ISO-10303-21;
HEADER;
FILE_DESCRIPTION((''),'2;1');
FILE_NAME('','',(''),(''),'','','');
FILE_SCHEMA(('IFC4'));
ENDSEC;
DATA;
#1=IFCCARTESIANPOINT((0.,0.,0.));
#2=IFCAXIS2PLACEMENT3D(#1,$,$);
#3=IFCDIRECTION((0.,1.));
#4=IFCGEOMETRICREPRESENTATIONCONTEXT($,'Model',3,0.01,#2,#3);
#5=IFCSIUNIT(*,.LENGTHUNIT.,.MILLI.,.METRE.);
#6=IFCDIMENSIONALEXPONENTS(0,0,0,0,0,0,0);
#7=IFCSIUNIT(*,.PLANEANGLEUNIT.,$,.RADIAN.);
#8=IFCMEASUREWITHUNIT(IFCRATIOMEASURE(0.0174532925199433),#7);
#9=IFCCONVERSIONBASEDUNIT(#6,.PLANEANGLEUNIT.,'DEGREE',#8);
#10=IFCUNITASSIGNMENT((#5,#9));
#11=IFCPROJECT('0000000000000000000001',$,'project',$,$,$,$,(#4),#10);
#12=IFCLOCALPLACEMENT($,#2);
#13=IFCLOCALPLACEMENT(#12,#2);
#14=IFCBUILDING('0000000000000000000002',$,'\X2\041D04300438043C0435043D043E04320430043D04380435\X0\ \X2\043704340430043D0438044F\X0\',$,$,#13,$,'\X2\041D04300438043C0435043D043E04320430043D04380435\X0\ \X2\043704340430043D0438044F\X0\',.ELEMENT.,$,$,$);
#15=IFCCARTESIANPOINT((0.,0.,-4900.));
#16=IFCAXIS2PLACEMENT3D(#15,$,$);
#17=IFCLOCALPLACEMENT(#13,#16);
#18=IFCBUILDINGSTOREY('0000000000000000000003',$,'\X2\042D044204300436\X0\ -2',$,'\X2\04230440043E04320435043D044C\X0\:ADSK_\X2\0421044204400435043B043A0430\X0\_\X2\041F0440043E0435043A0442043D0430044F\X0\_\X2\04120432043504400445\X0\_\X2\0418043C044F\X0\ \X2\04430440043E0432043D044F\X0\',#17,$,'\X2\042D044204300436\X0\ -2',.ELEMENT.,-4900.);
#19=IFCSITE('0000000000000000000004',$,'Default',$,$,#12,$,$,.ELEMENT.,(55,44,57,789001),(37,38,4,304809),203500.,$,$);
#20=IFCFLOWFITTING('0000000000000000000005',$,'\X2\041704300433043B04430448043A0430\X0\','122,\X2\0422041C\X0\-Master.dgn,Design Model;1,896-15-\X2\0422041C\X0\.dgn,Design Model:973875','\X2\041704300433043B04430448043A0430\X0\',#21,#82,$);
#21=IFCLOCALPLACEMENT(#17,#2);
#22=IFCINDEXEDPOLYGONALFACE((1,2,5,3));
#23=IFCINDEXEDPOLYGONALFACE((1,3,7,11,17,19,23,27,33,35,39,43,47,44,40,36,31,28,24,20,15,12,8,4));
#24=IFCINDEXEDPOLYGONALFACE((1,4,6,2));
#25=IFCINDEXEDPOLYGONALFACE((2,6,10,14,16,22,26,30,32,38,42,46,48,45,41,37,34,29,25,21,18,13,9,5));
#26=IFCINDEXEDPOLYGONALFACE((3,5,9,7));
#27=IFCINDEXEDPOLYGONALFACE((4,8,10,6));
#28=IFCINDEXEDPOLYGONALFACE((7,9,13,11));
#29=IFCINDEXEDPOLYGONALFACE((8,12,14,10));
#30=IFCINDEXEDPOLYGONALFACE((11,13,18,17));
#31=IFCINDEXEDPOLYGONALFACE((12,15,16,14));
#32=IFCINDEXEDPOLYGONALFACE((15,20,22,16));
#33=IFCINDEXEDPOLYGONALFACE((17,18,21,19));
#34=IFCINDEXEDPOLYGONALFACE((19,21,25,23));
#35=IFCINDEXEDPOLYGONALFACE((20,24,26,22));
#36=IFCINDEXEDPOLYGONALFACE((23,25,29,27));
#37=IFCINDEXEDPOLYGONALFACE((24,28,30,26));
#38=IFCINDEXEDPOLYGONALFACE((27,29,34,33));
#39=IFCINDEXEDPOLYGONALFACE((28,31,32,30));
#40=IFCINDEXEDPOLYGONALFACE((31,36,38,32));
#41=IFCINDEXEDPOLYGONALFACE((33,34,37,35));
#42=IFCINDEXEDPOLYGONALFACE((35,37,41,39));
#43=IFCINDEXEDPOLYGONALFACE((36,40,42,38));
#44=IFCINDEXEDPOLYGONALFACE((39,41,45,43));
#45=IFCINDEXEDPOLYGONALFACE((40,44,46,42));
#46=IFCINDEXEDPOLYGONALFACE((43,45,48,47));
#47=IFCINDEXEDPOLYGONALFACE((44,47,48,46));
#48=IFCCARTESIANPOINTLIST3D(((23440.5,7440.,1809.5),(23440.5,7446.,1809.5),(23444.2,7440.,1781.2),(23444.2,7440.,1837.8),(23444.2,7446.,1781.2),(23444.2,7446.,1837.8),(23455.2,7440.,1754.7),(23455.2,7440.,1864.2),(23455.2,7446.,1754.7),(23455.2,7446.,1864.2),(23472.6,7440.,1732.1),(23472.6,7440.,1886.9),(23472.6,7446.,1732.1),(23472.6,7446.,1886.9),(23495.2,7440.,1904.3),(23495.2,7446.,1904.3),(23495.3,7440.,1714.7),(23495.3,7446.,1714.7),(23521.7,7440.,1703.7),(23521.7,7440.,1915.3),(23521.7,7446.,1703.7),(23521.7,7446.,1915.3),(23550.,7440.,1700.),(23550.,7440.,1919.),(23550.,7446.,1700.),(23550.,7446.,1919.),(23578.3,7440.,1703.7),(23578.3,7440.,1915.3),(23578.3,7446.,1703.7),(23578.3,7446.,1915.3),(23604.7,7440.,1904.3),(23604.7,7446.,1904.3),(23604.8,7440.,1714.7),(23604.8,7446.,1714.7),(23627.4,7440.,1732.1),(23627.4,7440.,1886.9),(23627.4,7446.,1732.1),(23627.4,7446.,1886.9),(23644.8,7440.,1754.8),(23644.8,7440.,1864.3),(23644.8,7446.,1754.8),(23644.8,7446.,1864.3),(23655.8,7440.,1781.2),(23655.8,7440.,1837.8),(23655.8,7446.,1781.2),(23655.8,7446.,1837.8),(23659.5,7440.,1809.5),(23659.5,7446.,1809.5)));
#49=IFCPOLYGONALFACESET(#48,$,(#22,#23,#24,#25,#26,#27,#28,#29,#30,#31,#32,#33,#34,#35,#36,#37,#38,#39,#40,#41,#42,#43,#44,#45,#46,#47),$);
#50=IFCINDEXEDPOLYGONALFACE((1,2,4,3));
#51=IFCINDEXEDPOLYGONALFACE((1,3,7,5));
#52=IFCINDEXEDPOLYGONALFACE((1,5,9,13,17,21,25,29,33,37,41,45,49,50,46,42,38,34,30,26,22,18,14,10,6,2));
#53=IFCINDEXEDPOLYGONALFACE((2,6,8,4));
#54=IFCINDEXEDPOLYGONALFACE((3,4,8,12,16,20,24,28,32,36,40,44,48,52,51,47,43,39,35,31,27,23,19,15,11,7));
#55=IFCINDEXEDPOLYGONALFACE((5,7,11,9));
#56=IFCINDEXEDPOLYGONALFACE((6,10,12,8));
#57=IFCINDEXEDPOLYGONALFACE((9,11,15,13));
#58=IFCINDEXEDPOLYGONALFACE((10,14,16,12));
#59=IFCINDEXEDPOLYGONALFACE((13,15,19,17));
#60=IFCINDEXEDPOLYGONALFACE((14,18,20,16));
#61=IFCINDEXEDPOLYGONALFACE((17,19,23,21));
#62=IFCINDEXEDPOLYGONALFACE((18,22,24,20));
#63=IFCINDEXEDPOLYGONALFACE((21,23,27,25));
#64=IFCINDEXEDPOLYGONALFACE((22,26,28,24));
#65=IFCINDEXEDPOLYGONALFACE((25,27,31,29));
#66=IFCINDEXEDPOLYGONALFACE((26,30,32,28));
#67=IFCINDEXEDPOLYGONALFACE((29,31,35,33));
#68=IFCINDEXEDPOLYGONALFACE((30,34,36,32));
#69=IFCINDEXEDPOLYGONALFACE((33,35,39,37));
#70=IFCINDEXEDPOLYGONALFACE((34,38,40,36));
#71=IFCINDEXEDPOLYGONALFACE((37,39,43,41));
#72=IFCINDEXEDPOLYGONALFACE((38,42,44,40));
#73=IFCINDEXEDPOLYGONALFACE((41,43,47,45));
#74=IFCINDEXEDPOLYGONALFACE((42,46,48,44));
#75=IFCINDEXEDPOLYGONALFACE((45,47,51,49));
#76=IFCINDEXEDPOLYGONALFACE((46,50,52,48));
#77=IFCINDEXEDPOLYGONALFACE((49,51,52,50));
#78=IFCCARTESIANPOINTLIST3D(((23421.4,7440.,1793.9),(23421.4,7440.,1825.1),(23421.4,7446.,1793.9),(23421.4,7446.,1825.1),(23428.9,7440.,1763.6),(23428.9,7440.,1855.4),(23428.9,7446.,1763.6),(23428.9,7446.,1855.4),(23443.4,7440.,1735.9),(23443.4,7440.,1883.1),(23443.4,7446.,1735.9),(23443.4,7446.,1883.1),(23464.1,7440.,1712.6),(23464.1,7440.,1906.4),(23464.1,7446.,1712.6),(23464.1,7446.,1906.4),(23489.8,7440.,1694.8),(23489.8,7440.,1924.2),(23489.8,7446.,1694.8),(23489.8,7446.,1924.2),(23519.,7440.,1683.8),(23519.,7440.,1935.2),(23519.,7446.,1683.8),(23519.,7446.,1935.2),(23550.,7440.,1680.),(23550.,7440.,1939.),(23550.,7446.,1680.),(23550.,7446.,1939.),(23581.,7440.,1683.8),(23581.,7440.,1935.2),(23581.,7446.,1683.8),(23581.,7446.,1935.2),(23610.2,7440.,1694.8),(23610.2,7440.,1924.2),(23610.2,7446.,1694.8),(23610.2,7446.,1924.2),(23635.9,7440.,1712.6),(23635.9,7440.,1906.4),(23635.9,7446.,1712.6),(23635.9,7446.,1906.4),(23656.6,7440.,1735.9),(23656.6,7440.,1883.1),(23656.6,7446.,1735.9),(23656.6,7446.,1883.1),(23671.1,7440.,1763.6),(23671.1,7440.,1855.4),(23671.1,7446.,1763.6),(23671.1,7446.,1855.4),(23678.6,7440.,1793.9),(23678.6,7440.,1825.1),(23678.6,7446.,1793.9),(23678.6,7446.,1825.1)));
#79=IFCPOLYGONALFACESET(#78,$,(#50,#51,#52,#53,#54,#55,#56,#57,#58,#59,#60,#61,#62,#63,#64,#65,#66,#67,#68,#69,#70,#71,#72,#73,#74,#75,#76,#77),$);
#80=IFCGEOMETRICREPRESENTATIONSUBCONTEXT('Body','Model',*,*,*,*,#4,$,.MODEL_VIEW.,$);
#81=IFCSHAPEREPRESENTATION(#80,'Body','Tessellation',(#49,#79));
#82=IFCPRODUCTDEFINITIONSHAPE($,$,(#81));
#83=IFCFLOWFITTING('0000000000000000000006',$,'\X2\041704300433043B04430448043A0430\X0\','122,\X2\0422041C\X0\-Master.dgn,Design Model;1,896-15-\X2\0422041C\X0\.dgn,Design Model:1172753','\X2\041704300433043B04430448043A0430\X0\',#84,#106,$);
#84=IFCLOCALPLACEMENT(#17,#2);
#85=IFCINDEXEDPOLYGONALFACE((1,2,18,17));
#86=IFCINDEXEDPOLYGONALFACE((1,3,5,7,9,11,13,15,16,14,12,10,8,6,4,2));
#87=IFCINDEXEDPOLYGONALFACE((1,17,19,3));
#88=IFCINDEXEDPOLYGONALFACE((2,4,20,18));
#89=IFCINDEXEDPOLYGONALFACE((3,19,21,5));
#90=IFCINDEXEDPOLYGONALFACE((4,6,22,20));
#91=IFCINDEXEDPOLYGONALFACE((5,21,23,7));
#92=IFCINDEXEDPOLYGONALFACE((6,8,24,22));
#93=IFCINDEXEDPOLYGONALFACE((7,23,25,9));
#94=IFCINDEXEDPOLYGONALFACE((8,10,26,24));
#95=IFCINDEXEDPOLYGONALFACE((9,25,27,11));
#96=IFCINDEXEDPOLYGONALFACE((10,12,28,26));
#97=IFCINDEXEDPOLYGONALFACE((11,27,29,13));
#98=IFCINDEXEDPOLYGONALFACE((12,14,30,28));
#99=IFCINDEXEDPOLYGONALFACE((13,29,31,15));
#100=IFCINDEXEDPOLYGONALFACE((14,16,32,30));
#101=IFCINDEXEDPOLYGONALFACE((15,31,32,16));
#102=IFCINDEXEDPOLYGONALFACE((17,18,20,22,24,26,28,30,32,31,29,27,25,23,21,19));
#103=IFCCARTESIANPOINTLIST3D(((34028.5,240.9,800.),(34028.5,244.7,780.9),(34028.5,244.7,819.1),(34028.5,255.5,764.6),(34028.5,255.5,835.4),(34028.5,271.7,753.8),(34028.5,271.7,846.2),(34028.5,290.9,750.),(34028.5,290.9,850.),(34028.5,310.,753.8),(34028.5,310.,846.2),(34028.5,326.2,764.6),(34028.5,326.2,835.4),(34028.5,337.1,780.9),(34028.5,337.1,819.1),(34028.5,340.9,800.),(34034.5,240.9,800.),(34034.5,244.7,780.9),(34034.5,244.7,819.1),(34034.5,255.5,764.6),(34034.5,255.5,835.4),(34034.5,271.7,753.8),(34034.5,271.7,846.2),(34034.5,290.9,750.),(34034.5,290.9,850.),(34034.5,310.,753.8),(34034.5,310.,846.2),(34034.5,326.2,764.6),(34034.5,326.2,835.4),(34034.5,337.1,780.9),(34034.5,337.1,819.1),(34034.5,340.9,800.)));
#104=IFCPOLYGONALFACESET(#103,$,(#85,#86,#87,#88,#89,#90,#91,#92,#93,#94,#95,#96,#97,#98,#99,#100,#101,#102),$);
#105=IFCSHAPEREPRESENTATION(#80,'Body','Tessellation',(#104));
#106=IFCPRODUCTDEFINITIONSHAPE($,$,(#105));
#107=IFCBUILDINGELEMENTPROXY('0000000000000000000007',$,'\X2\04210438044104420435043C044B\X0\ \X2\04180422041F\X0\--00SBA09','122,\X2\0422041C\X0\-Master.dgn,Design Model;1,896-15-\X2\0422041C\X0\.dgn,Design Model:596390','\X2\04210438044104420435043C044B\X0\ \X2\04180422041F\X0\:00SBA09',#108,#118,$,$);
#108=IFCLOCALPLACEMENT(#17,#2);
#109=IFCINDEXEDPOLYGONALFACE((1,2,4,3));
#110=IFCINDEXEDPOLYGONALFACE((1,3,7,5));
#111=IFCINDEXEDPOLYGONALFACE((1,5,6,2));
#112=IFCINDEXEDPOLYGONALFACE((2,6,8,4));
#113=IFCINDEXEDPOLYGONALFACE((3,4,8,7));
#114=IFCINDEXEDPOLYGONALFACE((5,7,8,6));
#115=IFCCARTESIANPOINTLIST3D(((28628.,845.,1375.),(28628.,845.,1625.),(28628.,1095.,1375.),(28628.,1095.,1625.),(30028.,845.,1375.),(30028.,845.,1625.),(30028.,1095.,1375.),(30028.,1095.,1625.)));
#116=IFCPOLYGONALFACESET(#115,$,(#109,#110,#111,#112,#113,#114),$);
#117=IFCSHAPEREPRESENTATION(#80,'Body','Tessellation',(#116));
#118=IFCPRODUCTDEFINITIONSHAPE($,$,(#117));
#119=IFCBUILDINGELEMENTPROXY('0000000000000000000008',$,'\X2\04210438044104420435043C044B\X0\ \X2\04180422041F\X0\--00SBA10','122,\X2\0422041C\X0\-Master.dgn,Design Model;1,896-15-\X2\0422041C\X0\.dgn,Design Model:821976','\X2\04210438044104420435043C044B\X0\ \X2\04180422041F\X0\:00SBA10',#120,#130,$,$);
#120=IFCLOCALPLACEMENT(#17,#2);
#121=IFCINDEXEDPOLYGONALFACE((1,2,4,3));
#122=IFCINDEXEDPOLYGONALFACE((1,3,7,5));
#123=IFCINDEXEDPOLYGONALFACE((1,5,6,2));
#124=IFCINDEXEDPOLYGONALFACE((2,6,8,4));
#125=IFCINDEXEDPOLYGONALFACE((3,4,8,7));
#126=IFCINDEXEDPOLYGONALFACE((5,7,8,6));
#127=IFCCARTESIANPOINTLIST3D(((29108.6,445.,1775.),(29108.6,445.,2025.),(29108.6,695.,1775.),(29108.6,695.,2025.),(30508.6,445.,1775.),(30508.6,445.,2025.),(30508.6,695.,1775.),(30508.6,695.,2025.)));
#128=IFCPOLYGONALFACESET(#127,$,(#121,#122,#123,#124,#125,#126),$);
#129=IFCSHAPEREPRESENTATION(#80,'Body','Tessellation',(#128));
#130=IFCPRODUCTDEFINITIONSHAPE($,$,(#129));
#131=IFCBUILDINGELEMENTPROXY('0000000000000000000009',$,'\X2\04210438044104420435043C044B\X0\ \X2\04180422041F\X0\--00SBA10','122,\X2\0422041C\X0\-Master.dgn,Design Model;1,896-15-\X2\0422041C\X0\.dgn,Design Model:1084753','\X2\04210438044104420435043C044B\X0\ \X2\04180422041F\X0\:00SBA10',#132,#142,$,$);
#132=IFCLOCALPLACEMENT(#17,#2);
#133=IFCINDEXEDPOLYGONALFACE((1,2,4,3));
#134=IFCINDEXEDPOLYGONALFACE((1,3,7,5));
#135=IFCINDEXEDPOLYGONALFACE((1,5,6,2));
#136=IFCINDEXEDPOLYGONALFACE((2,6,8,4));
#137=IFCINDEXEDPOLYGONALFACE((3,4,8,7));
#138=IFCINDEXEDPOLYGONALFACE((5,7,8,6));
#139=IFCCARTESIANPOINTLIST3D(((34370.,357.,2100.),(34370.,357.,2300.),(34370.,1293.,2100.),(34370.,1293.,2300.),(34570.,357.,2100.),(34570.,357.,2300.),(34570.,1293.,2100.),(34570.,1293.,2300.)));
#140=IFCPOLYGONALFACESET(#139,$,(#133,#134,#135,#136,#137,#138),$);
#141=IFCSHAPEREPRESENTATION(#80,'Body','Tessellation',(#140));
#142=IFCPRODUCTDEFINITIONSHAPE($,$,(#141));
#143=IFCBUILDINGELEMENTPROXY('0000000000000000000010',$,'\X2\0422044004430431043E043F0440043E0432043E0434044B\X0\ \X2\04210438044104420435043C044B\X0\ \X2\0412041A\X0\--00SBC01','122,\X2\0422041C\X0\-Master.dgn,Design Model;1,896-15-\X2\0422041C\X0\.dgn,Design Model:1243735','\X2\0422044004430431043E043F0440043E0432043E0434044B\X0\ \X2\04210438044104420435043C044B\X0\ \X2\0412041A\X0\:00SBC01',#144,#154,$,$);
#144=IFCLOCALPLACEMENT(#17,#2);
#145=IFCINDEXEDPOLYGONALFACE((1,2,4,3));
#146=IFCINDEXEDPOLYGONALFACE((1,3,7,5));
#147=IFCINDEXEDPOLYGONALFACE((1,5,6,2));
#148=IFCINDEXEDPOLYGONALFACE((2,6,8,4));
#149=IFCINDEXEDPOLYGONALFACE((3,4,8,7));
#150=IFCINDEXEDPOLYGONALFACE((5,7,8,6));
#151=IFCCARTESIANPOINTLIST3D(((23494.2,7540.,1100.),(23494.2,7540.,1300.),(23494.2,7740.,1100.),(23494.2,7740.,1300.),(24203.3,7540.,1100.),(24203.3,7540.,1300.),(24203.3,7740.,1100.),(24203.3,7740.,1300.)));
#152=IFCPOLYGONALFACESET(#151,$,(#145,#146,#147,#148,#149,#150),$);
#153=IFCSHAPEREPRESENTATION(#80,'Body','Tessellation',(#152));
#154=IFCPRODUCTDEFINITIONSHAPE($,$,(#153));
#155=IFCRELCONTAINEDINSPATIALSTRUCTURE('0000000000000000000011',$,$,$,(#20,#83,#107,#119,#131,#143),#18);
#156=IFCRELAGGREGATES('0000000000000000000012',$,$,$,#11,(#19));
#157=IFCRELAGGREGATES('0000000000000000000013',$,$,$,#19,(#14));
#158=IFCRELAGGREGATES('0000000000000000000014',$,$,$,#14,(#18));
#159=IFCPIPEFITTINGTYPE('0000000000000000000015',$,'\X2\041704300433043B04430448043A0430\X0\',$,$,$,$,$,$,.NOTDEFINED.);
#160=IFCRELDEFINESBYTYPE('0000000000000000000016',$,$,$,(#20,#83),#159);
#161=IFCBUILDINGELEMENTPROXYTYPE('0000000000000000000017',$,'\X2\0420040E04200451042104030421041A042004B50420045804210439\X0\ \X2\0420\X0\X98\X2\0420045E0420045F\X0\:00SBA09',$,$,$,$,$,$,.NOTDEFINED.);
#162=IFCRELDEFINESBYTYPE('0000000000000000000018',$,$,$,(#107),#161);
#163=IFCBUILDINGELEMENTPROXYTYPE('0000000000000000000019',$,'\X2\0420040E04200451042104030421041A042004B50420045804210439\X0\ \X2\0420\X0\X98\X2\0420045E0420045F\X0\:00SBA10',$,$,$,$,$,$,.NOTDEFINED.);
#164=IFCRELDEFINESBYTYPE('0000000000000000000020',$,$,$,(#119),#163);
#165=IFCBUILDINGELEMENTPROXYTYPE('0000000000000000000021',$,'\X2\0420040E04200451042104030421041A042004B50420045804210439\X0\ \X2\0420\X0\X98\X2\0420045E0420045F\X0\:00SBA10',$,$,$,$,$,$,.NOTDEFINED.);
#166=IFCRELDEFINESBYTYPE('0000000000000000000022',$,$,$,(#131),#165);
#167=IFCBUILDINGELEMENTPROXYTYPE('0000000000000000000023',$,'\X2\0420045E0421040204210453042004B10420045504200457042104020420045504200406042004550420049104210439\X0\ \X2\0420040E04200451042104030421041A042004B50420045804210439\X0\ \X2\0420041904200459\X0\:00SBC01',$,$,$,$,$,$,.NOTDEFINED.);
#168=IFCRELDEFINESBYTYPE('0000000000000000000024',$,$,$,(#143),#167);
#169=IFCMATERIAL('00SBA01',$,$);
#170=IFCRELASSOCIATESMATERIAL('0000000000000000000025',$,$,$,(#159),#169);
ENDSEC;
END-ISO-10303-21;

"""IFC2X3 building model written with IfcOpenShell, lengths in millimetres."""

from ifc_helpers import new_model, entity, si_unit, converted_unit, direction, frame, origin, origin_2d_with_axis, place, context, subcontext, project, spatial, polyline, rectangle, outline, extrude, material, type_object, element, save


model = new_model("IFC2X3")

# Units and contexts
model_context = context("Model", 3, precision=0.01, world=origin(), true_north=direction((0.0, 1.0)))
body_context = subcontext(model_context, "Body", "Model", "MODEL_VIEW")
ifc_project = project(units=[si_unit("LENGTHUNIT", "METRE", prefix="MILLI"), converted_unit("PLANEANGLEUNIT", "DEGREE", entity("IfcRatioMeasure", 0.0174532925199433), si_unit("PLANEANGLEUNIT", "RADIAN"), dimensions=[0, 0, 0, 0, 0, 0, 0])], contexts=[model_context])

# Site, building, storey
site_placement = place(None, origin())
site = spatial("IfcSite", under=ifc_project, at=site_placement, Name="Default", CompositionType="ELEMENT", RefLatitude=(55, 44, 57, 789001), RefLongitude=(37, 38, 4, 304809), RefElevation=203500.0)
building_placement = place(site_placement, origin())
building = spatial("IfcBuilding", under=site, at=building_placement, Name="Наименование здания", LongName="Наименование здания", CompositionType="ELEMENT")
storey_placement = place(building_placement, frame((0.0, 0.0, -4900.0)))
storey = spatial("IfcBuildingStorey", under=building, at=storey_placement, Name="Этаж -2", ObjectType="Уровень:ADSK_Стрелка_Проектная_Вверх_Имя уровня", LongName="Этаж -2", CompositionType="ELEMENT", Elevation=-4900.0)

# Flow fittings
ifc_material_1 = material(Name="00SBA01")
pipe_fitting_type_1 = type_object("IfcPipeFittingType", Name="Заглушка", PredefinedType="NOTDEFINED", material=ifc_material_1)
flow_fitting_1_placement = place(storey_placement, frame((23421.4, 7440.0, 1680.0)))
element("IfcFlowFitting", 1, at=flow_fitting_1_placement, inside=storey, type_object=pipe_fitting_type_1, Name="Заглушка", Description="122,ТМ-Master.dgn,Design Model;1,896-15-ТМ.dgn,Design Model:973875", ObjectType="Заглушка", context=body_context, shape_type="SweptSolid", body=[
    extrude(outline(polyline([(-14.3, -108.6), (14.3, -108.6), (41.9, -101.2), (66.7, -86.9), (86.9, -66.7), (101.2, -41.9), (108.6, -14.3), (108.6, 14.3), (101.2, 41.9), (86.9, 66.7), (66.7, 86.9), (41.9, 101.2), (14.3, 108.6), (-14.3, 108.6), (-41.9, 101.2), (-66.7, 86.9), (-86.9, 66.7), (-101.2, 41.9), (-108.6, 14.3), (-108.6, -14.3), (-101.2, -41.9), (-86.9, -66.7), (-66.7, -86.9), (-41.9, -101.2), (-14.3, -108.6)])), frame((128.6, 0.0, 129.5), z_axis=(0.0, 1.0, 0.0), x_axis=(0.991445, 0.0, -0.130526)), (0.0, 0.0, 1.0), 6.0),
    extrude(outline(polyline([(-15.6, -128.6), (15.6, -128.6), (45.9, -121.1), (73.6, -106.6), (96.9, -85.9), (114.7, -60.2), (125.7, -31.0), (129.5, 0.0), (125.7, 31.0), (114.7, 60.2), (96.9, 85.9), (73.6, 106.6), (45.9, 121.1), (15.6, 128.6), (-15.6, 128.6), (-45.9, 121.1), (-73.6, 106.6), (-96.9, 85.9), (-114.7, 60.2), (-125.7, 31.0), (-129.5, 0.0), (-125.7, -31.0), (-114.7, -60.2), (-96.9, -85.9), (-73.6, -106.6), (-45.9, -121.1), (-15.6, -128.6)])), frame((128.6, 0.0, 129.5), z_axis=(0.0, 1.0, 0.0), x_axis=(0.992709, 0.0, -0.120537)), (0.0, 0.0, 1.0), 6.0),
])
flow_fitting_2_placement = place(storey_placement, frame((34028.5, 240.9, 750.0)))
element("IfcFlowFitting", 2, at=flow_fitting_2_placement, inside=storey, type_object=pipe_fitting_type_1, Name="Заглушка", Description="122,ТМ-Master.dgn,Design Model;1,896-15-ТМ.dgn,Design Model:1172753", ObjectType="Заглушка", context=body_context, shape_type="SweptSolid", body=[
    extrude(outline(polyline([(-9.8, -49.0), (9.8, -49.0), (27.8, -41.6), (41.6, -27.8), (49.0, -9.8), (49.0, 9.8), (41.6, 27.8), (27.8, 41.6), (9.8, 49.0), (-9.8, 49.0), (-27.8, 41.6), (-41.6, 27.8), (-49.0, 9.8), (-49.0, -9.8), (-41.6, -27.8), (-27.8, -41.6), (-9.8, -49.0)])), frame((0.0, 50.0, 50.0), z_axis=(1.0, 0.0, 0.0), x_axis=(0.0, -0.980785, -0.19509)), (0.0, 0.0, 1.0), 6.0),
])

# Building element proxies
building_element_proxy_type_1 = type_object("IfcBuildingElementProxyType", Name="РЎРёСЃСКРҵРјСй РX98РўРџ:00SBA09", PredefinedType="NOTDEFINED")
proxy_1_placement = place(storey_placement, frame((28628.0, 845.0, 1375.0)))
element("IfcBuildingElementProxy", 3, at=proxy_1_placement, inside=storey, type_object=building_element_proxy_type_1, Name="Системы ИТП--00SBA09", Description="122,ТМ-Master.dgn,Design Model;1,896-15-ТМ.dgn,Design Model:596390", ObjectType="Системы ИТП:00SBA09", context=body_context, shape_type="SweptSolid", body=[
    extrude(rectangle(XDim=250.0, YDim=1400.0, at=origin_2d_with_axis()), frame((700.0, 125.0, 0.0), z_axis=(0.0, 0.0, 1.0), x_axis=(0.0, -1.0, 0.0)), (0.0, 0.0, 1.0), 250.0),
])
building_element_proxy_type_2 = type_object("IfcBuildingElementProxyType", Name="РЎРёСЃСКРҵРјСй РX98РўРџ:00SBA10", PredefinedType="NOTDEFINED")
proxy_2_placement = place(storey_placement, frame((29108.6, 445.0, 1775.0)))
element("IfcBuildingElementProxy", 4, at=proxy_2_placement, inside=storey, type_object=building_element_proxy_type_2, Name="Системы ИТП--00SBA10", Description="122,ТМ-Master.dgn,Design Model;1,896-15-ТМ.dgn,Design Model:821976", ObjectType="Системы ИТП:00SBA10", context=body_context, shape_type="SweptSolid", body=[
    extrude(rectangle(XDim=250.0, YDim=1400.0, at=origin_2d_with_axis()), frame((700.0, 125.0, 0.0), z_axis=(0.0, 0.0, 1.0), x_axis=(0.0, -1.0, 0.0)), (0.0, 0.0, 1.0), 250.0),
])
building_element_proxy_type_3 = type_object("IfcBuildingElementProxyType", Name="РЎРёСЃСКРҵРјСй РX98РўРџ:00SBA10", PredefinedType="NOTDEFINED")
proxy_3_placement = place(storey_placement, frame((34370.0, 357.0, 2100.0)))
element("IfcBuildingElementProxy", 5, at=proxy_3_placement, inside=storey, type_object=building_element_proxy_type_3, Name="Системы ИТП--00SBA10", Description="122,ТМ-Master.dgn,Design Model;1,896-15-ТМ.dgn,Design Model:1084753", ObjectType="Системы ИТП:00SBA10", context=body_context, shape_type="SweptSolid", body=[
    extrude(rectangle(XDim=200.0, YDim=936.0, at=origin_2d_with_axis()), frame((100.0, 468.0, 0.0), z_axis=(0.0, 0.0, 1.0), x_axis=(-1.0, 0.0, 0.0)), (0.0, 0.0, 1.0), 200.0),
])
building_element_proxy_type_4 = type_object("IfcBuildingElementProxyType", Name="РўСЂСѓРұРѕРїСЂРѕРІРѕРґСй РЎРёСЃСКРҵРјСй РЙРљ:00SBC01", PredefinedType="NOTDEFINED")
proxy_4_placement = place(storey_placement, frame((23494.2, 7540.0, 1100.0)))
element("IfcBuildingElementProxy", 6, at=proxy_4_placement, inside=storey, type_object=building_element_proxy_type_4, Name="Трубопроводы Системы ВК--00SBC01", Description="122,ТМ-Master.dgn,Design Model;1,896-15-ТМ.dgn,Design Model:1243735", ObjectType="Трубопроводы Системы ВК:00SBC01", context=body_context, shape_type="SweptSolid", body=[
    extrude(rectangle(XDim=709.1, YDim=200.0, at=origin_2d_with_axis()), frame((354.6, 100.0, 0.0)), (0.0, 0.0, 1.0), 200.0),
])

save(model, "model.ifc")
